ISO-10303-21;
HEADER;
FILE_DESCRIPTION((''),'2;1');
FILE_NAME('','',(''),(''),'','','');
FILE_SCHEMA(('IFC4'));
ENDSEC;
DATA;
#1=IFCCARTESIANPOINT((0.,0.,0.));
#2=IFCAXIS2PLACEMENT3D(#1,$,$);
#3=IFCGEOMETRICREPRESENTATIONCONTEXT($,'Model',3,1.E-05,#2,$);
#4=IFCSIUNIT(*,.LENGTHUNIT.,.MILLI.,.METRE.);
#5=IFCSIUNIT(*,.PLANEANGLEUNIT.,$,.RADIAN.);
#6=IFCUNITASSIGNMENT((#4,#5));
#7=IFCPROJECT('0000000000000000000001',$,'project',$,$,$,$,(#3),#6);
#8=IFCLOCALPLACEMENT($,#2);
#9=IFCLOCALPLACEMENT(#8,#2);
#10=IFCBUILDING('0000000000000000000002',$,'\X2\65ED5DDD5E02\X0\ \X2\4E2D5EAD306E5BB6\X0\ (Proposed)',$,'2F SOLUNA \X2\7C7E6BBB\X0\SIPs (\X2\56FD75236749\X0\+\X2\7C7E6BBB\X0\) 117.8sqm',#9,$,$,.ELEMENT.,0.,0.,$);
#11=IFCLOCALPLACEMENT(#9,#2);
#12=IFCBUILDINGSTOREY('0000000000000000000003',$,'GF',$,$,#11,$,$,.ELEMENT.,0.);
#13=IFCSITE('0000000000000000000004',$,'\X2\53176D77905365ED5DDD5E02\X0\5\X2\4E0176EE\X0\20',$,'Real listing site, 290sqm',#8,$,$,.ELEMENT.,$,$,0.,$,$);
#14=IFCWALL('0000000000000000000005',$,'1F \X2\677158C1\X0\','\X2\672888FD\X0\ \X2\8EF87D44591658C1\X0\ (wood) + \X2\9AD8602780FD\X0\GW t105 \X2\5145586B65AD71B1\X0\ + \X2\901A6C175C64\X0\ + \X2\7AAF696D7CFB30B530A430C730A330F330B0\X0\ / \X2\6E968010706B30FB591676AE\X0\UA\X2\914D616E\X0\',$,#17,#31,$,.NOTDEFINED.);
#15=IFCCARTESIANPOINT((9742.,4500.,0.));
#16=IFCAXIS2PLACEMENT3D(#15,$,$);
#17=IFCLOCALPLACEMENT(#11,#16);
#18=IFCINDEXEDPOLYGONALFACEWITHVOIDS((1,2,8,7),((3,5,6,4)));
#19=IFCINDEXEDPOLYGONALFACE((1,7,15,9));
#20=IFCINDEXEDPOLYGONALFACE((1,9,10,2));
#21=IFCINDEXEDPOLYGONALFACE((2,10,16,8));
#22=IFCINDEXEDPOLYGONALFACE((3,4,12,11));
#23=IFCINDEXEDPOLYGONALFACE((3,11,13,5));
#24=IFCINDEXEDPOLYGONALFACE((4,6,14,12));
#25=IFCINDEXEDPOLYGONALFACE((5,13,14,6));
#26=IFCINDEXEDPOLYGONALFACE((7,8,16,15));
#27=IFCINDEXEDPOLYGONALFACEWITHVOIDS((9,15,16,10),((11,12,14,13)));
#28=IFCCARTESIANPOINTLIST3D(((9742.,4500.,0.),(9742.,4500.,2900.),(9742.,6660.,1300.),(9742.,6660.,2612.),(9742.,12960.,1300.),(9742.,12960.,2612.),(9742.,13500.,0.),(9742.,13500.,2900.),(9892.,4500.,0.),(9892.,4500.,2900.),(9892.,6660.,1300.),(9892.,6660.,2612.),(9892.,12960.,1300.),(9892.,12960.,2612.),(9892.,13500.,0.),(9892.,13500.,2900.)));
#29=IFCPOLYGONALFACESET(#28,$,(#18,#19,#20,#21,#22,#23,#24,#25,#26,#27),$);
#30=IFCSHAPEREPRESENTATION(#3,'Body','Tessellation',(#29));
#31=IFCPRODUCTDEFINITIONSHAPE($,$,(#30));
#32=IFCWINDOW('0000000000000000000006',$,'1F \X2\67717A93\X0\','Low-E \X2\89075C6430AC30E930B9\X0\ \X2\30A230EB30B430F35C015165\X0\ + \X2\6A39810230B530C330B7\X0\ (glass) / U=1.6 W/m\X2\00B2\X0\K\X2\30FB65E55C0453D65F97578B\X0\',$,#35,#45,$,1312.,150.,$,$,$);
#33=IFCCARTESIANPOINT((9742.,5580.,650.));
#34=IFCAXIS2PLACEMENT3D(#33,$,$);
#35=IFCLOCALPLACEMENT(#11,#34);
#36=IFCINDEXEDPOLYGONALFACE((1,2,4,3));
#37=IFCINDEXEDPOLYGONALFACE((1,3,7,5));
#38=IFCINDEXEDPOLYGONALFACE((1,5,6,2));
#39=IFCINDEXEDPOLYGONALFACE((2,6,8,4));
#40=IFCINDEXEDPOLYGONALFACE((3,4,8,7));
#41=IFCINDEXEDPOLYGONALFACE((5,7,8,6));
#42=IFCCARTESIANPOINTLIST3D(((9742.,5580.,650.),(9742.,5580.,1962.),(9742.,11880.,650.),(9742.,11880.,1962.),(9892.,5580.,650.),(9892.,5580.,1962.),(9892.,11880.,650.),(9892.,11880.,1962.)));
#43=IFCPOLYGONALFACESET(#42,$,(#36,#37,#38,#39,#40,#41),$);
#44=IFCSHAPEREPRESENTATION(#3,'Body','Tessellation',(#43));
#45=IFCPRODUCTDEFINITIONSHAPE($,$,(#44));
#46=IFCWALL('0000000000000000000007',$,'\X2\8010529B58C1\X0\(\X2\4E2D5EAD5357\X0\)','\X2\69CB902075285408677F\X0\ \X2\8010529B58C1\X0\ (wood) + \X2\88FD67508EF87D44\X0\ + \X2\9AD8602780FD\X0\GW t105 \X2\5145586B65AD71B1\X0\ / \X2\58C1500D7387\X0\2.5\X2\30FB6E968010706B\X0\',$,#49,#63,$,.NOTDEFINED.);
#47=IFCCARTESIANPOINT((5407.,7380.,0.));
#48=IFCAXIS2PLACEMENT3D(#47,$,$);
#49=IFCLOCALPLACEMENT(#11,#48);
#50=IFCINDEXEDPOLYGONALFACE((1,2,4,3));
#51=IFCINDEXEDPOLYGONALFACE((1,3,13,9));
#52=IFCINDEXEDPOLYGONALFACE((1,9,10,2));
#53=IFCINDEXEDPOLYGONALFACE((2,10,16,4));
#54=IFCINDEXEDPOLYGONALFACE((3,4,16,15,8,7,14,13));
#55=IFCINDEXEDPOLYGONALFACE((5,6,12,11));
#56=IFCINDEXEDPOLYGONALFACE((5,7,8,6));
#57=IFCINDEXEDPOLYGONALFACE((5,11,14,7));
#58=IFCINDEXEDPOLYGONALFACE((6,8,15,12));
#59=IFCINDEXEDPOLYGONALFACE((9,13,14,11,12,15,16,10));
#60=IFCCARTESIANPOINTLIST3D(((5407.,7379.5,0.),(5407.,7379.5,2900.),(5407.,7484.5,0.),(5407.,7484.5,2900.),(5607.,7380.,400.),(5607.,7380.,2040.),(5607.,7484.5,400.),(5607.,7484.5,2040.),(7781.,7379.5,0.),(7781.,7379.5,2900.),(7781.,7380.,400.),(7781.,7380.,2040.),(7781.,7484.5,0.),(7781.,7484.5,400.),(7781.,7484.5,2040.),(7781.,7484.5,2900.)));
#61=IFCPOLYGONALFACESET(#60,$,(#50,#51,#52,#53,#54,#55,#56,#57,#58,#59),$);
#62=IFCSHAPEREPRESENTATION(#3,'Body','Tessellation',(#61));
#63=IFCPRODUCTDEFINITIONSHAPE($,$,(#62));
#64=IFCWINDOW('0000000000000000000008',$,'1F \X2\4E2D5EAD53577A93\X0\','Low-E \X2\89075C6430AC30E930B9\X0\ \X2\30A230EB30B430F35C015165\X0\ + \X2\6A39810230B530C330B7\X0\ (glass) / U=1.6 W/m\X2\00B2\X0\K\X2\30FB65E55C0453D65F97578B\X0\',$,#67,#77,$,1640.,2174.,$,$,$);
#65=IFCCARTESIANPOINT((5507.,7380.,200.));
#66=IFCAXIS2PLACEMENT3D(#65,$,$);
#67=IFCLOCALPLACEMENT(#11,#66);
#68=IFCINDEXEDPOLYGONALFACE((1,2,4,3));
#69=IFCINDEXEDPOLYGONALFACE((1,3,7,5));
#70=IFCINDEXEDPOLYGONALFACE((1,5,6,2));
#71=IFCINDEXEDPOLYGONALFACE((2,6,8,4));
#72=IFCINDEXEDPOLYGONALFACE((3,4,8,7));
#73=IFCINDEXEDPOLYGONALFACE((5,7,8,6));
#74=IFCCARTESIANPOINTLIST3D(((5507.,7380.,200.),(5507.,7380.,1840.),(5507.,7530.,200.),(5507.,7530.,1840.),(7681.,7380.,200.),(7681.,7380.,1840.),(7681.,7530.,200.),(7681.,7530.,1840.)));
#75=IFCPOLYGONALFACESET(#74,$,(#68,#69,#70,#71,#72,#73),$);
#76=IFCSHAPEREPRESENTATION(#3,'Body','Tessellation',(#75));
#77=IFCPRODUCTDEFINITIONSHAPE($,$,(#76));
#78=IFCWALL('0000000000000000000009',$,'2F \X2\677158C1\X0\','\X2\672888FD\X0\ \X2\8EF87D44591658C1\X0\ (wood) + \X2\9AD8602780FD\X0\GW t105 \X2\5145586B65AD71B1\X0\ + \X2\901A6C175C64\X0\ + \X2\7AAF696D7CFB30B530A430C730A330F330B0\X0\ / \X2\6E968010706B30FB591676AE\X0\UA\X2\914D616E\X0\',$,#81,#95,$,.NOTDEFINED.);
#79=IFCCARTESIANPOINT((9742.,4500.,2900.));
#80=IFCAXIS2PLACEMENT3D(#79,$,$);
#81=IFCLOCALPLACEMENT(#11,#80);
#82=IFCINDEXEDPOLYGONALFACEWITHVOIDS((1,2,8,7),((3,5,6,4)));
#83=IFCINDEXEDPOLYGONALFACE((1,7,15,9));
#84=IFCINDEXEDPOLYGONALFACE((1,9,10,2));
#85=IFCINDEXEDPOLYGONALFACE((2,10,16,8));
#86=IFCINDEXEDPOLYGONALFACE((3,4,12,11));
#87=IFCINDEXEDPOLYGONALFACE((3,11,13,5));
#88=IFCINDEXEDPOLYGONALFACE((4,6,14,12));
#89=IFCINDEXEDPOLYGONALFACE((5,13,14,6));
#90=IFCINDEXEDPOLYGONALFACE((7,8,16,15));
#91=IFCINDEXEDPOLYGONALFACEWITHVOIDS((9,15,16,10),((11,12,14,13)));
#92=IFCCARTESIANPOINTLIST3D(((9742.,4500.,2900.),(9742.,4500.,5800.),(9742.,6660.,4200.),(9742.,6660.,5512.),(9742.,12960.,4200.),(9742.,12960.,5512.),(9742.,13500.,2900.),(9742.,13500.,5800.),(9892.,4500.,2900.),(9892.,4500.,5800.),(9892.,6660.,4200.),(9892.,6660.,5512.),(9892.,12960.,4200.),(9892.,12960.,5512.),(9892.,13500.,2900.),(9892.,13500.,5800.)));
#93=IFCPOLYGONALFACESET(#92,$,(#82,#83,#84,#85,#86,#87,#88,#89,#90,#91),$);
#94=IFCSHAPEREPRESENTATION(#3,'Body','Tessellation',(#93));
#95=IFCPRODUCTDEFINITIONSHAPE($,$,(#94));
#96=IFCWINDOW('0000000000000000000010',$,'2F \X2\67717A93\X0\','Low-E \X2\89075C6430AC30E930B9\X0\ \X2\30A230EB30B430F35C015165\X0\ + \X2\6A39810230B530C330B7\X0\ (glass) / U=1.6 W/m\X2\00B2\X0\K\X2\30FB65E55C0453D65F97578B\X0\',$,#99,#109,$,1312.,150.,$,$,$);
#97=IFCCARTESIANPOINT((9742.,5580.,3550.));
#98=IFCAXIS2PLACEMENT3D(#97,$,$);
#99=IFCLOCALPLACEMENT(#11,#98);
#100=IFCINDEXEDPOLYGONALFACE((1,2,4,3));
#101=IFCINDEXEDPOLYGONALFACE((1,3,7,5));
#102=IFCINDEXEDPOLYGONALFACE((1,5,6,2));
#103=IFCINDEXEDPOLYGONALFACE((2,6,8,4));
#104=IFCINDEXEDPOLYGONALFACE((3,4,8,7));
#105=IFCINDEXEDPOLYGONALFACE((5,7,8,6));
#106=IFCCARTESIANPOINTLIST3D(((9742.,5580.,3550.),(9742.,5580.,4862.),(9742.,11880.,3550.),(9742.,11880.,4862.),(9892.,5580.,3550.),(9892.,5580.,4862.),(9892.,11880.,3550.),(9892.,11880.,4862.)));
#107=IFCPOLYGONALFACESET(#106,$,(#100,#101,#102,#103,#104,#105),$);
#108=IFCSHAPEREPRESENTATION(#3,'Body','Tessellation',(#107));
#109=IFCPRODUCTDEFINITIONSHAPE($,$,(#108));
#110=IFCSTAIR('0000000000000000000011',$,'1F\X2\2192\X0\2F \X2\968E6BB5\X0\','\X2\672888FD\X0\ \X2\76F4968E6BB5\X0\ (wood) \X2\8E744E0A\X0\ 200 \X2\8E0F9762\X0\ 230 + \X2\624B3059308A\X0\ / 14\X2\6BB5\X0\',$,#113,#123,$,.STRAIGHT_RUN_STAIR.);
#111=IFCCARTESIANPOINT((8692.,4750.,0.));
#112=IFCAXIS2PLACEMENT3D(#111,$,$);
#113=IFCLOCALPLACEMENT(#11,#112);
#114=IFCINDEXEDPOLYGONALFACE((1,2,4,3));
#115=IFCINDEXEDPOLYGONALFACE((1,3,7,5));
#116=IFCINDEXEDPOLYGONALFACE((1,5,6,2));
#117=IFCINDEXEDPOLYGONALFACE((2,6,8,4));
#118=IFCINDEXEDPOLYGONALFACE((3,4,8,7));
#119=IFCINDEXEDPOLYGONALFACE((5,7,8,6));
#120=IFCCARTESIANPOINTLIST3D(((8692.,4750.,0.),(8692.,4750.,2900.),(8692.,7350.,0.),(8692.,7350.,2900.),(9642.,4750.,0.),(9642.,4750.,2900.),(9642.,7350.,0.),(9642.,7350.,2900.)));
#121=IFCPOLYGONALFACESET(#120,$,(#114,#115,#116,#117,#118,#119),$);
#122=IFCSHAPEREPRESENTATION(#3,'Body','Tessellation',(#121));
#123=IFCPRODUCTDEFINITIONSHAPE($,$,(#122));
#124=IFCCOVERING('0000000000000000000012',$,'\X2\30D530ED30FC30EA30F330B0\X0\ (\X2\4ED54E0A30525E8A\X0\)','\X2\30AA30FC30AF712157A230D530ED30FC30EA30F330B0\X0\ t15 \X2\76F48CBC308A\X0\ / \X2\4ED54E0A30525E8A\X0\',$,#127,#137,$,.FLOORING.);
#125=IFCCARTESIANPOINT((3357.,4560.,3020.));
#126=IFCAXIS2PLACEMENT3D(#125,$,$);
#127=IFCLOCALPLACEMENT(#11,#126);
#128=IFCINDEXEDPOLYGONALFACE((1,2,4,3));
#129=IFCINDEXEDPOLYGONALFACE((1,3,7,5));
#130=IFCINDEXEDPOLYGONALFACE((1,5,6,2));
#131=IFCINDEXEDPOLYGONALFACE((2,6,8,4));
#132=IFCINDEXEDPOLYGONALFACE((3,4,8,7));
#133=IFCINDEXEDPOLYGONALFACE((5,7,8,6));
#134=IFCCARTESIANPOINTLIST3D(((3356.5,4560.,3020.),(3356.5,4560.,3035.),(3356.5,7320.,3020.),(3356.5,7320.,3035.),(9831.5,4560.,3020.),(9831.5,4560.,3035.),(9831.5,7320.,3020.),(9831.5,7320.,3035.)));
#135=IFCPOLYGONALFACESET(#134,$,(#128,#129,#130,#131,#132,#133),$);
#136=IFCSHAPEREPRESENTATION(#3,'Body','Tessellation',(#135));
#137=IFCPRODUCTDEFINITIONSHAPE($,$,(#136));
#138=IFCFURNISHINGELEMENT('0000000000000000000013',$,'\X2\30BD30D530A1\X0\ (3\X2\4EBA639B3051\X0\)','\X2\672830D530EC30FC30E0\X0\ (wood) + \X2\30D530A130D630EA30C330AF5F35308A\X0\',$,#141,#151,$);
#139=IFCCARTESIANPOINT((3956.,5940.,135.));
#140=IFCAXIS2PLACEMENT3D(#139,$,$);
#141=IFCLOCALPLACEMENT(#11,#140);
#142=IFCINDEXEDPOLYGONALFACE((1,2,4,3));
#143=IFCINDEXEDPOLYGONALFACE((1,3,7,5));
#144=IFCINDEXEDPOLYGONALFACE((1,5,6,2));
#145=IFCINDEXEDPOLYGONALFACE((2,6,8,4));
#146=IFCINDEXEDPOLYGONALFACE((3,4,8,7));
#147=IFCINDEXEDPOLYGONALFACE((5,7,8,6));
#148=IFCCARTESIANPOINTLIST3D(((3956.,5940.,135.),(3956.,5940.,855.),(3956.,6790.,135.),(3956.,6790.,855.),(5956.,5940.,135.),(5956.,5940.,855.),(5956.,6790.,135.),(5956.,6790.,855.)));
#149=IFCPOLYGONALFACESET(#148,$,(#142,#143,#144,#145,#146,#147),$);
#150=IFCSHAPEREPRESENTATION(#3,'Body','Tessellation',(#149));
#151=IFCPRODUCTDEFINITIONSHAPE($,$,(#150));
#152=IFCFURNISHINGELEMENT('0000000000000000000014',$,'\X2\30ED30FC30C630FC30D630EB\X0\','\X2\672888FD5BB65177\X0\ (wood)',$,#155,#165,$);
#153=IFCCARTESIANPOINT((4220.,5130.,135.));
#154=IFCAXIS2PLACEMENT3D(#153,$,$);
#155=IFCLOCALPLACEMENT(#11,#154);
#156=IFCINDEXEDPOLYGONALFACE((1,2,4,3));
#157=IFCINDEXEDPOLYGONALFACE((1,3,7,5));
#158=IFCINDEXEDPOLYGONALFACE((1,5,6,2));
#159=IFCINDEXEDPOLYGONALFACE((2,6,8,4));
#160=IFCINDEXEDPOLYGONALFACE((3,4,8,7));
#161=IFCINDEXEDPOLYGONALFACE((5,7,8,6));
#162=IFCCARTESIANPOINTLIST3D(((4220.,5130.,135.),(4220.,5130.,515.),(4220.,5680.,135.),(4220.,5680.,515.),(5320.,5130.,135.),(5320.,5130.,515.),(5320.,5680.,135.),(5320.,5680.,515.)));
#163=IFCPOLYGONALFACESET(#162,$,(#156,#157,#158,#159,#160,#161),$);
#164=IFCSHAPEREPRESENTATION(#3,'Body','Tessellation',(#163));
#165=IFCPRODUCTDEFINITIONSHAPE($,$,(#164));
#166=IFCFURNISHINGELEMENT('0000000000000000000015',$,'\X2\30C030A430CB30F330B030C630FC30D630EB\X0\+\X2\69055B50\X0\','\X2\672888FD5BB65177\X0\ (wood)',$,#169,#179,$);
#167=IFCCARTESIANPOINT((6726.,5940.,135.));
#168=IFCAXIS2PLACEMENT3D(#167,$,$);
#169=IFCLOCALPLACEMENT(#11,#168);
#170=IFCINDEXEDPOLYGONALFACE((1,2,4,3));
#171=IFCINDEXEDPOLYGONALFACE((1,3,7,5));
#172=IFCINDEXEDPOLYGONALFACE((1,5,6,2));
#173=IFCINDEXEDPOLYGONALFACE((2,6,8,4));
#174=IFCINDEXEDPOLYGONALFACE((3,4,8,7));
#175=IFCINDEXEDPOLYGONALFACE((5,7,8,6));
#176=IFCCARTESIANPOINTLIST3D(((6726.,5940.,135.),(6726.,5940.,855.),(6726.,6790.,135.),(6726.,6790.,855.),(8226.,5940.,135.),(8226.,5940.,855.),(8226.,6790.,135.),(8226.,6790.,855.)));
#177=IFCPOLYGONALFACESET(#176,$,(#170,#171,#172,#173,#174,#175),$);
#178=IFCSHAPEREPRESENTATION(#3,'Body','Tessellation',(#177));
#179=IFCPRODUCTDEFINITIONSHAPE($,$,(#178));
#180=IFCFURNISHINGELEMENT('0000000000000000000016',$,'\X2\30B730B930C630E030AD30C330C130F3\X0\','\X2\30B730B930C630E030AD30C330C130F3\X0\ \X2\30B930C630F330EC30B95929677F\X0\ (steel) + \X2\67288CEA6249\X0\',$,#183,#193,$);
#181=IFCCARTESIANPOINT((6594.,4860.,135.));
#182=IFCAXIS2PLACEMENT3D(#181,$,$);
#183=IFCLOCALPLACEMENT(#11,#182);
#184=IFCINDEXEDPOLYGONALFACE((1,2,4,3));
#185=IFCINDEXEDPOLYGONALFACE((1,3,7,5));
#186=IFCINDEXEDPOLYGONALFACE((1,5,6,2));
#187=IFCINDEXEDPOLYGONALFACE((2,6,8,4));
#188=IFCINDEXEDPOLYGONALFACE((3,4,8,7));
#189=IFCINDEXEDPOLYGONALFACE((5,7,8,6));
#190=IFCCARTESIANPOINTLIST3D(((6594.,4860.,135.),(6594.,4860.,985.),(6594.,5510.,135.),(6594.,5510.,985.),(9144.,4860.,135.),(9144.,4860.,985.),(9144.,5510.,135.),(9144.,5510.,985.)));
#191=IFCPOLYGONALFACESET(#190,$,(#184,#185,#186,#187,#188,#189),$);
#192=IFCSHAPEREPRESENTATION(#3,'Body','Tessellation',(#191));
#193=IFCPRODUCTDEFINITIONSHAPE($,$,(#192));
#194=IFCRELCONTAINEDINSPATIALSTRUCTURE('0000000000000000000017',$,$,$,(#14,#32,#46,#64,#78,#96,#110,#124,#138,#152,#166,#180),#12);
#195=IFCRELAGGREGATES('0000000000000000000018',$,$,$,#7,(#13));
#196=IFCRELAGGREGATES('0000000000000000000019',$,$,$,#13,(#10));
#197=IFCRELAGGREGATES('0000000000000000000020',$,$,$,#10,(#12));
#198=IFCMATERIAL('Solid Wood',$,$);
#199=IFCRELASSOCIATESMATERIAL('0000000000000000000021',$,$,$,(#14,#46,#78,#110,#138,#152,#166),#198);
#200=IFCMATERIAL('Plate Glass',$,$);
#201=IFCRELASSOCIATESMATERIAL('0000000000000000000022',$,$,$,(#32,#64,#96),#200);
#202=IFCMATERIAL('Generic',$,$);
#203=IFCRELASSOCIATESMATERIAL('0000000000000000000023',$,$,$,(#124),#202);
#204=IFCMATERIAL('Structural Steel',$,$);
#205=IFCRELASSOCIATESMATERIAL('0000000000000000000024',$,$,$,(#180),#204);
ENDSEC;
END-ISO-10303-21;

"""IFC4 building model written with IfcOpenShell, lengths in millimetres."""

from ifc_helpers import new_model, si_unit, frame, frame_2d, origin, place, context, project, spatial, rectangle, extrude, material, element, fill, save


model = new_model("IFC4")

# Units and contexts
model_context = context("Model", 3, precision=1e-05, world=origin())
ifc_project = project(units=[si_unit("LENGTHUNIT", "METRE", prefix="MILLI"), si_unit("PLANEANGLEUNIT", "RADIAN")], contexts=[model_context])

# Site, building, storey
site_placement = place(None, origin())
site = spatial("IfcSite", under=ifc_project, at=site_placement, Name="北海道旭川市5丁目20", ObjectType="Real listing site, 290sqm", CompositionType="ELEMENT", RefElevation=0.0)
building_placement = place(site_placement, origin())
building = spatial("IfcBuilding", under=site, at=building_placement, Name="旭川市 中庭の家 (Proposed)", ObjectType="2F SOLUNA 籾殻SIPs (国産杉+籾殻) 117.8sqm", CompositionType="ELEMENT", ElevationOfRefHeight=0.0, ElevationOfTerrain=0.0)
storey_placement = place(building_placement, origin())
storey = spatial("IfcBuildingStorey", under=building, at=storey_placement, Name="GF", CompositionType="ELEMENT", Elevation=0.0)

# Shared definitions
ifc_material_1 = material(Name="Solid Wood")

# Walls, openings, windows
wall_1_placement = place(storey_placement, frame((9742.0, 4500.0, 0.0)))
wall_1 = element("IfcWall", 1, at=wall_1_placement, inside=storey, material=ifc_material_1, Name="1F 東壁", Description="木製 軸組外壁 (wood) + 高性能GW t105 充填断熱 + 通気層 + 窯業系サイディング / 準耐火・外皮UA配慮", PredefinedType="NOTDEFINED", context=model_context, shape_type="SweptSolid", body=[
    extrude(rectangle(XDim=150.0, YDim=9000.0, at=frame_2d((75.0, 4500.0))), frame((9742.0, 4500.0, 0.0)), (0.0, 0.0, 1.0), 2900.0),
])
opening_1_placement = place(storey_placement, frame((9742.0, 5580.0, 650.0)))
opening_1 = element("IfcOpeningElement", 2, at=opening_1_placement, cuts=wall_1, PredefinedType="NOTDEFINED", context=model_context, shape_type="SweptSolid", body=[
    extrude(rectangle(XDim=150.0, YDim=6300.0, at=frame_2d((75.0, 3150.0))), frame((9742.0, 5580.0, 650.0)), (0.0, 0.0, 1.0), 1312.0),
])
ifc_material_2 = material(Name="Plate Glass")
window_1_placement = place(storey_placement, frame((9742.0, 5580.0, 650.0)))
window_1 = element("IfcWindow", 3, at=window_1_placement, inside=storey, material=ifc_material_2, Name="1F 東窓", Description="Low-E 複層ガラス アルゴン封入 + 樹脂サッシ (glass) / U=1.6 W/m²K・日射取得型", OverallHeight=1312.0, OverallWidth=150.0, context=model_context, shape_type="SweptSolid", body=[
    extrude(rectangle(XDim=150.0, YDim=6300.0, at=frame_2d((75.0, 3150.0))), frame((9742.0, 5580.0, 650.0)), (0.0, 0.0, 1.0), 1312.0),
])
fill(opening_1, window_1)
wall_2_placement = place(storey_placement, frame((5407.0, 7380.0, 0.0)))
wall_2 = element("IfcWall", 4, at=wall_2_placement, inside=storey, material=ifc_material_1, Name="耐力壁(中庭南)", Description="構造用合板 耐力壁 (wood) + 製材軸組 + 高性能GW t105 充填断熱 / 壁倍率2.5・準耐火", PredefinedType="NOTDEFINED", context=model_context, shape_type="SweptSolid", body=[
    extrude(rectangle(XDim=2374.0, YDim=105.0, at=frame_2d((1187.0, 52.0))), frame((5407.0, 7380.0, 0.0)), (0.0, 0.0, 1.0), 2900.0),
])
opening_2_placement = place(storey_placement, frame((5507.0, 7380.0, 200.0)))
opening_2 = element("IfcOpeningElement", 5, at=opening_2_placement, cuts=wall_2, PredefinedType="NOTDEFINED", context=model_context, shape_type="SweptSolid", body=[
    extrude(rectangle(XDim=2174.0, YDim=150.0, at=frame_2d((1087.0, 75.0))), frame((5507.0, 7380.0, 200.0)), (0.0, 0.0, 1.0), 1640.0),
])
window_2_placement = place(storey_placement, frame((5507.0, 7380.0, 200.0)))
window_2 = element("IfcWindow", 6, at=window_2_placement, inside=storey, material=ifc_material_2, Name="1F 中庭南窓", Description="Low-E 複層ガラス アルゴン封入 + 樹脂サッシ (glass) / U=1.6 W/m²K・日射取得型", OverallHeight=1640.0, OverallWidth=2174.0, context=model_context, shape_type="SweptSolid", body=[
    extrude(rectangle(XDim=2174.0, YDim=150.0, at=frame_2d((1087.0, 75.0))), frame((5507.0, 7380.0, 200.0)), (0.0, 0.0, 1.0), 1640.0),
])
fill(opening_2, window_2)

# Wall, opening, window
wall_3_placement = place(storey_placement, frame((9742.0, 4500.0, 2900.0)))
wall_3 = element("IfcWall", 7, at=wall_3_placement, inside=storey, material=ifc_material_1, Name="2F 東壁", Description="木製 軸組外壁 (wood) + 高性能GW t105 充填断熱 + 通気層 + 窯業系サイディング / 準耐火・外皮UA配慮", PredefinedType="NOTDEFINED", context=model_context, shape_type="SweptSolid", body=[
    extrude(rectangle(XDim=150.0, YDim=9000.0, at=frame_2d((75.0, 4500.0))), frame((9742.0, 4500.0, 2900.0)), (0.0, 0.0, 1.0), 2900.0),
])
opening_3_placement = place(storey_placement, frame((9742.0, 5580.0, 3550.0)))
opening_3 = element("IfcOpeningElement", 8, at=opening_3_placement, cuts=wall_3, PredefinedType="NOTDEFINED", context=model_context, shape_type="SweptSolid", body=[
    extrude(rectangle(XDim=150.0, YDim=6300.0, at=frame_2d((75.0, 3150.0))), frame((9742.0, 5580.0, 3550.0)), (0.0, 0.0, 1.0), 1312.0),
])
window_3_placement = place(storey_placement, frame((9742.0, 5580.0, 3550.0)))
window_3 = element("IfcWindow", 9, at=window_3_placement, inside=storey, material=ifc_material_2, Name="2F 東窓", Description="Low-E 複層ガラス アルゴン封入 + 樹脂サッシ (glass) / U=1.6 W/m²K・日射取得型", OverallHeight=1312.0, OverallWidth=150.0, context=model_context, shape_type="SweptSolid", body=[
    extrude(rectangle(XDim=150.0, YDim=6300.0, at=frame_2d((75.0, 3150.0))), frame((9742.0, 5580.0, 3550.0)), (0.0, 0.0, 1.0), 1312.0),
])
fill(opening_3, window_3)

# Stair
stair_placement = place(storey_placement, frame((8692.0, 4750.0, 0.0)))
element("IfcStair", 10, at=stair_placement, inside=storey, material=ifc_material_1, Name="1F→2F 階段", Description="木製 直階段 (wood) 蹴上 200 踏面 230 + 手すり / 14段", PredefinedType="STRAIGHT_RUN_STAIR", context=model_context, shape_type="SweptSolid", body=[
    extrude(rectangle(XDim=950.0, YDim=2600.0, at=frame_2d((475.0, 1300.0))), frame((8692.0, 4750.0, 0.0)), (0.0, 0.0, 1.0), 2900.0),
])

# Covering
ifc_material_3 = material(Name="Generic")
covering_placement = place(storey_placement, frame((3357.0, 4560.0, 3020.0)))
element("IfcCovering", 11, at=covering_placement, inside=storey, material=ifc_material_3, Name="フローリング (仕上げ床)", Description="オーク無垢フローリング t15 直貼り / 仕上げ床", PredefinedType="FLOORING", context=model_context, shape_type="SweptSolid", body=[
    extrude(rectangle(XDim=6475.0, YDim=2760.0, at=frame_2d((3237.0, 1380.0))), frame((3357.0, 4560.0, 3020.0)), (0.0, 0.0, 1.0), 15.0),
])

# Furnishing elements
furnishing_1_placement = place(storey_placement, frame((3956.0, 5940.0, 135.0)))
element("IfcFurnishingElement", 12, at=furnishing_1_placement, inside=storey, material=ifc_material_1, Name="ソファ (3人掛け)", Description="木フレーム (wood) + ファブリック張り", context=model_context, shape_type="SweptSolid", body=[
    extrude(rectangle(XDim=2000.0, YDim=850.0, at=frame_2d((1000.0, 425.0))), frame((3956.0, 5940.0, 135.0)), (0.0, 0.0, 1.0), 720.0),
])
furnishing_2_placement = place(storey_placement, frame((4220.0, 5130.0, 135.0)))
element("IfcFurnishingElement", 13, at=furnishing_2_placement, inside=storey, material=ifc_material_1, Name="ローテーブル", Description="木製家具 (wood)", context=model_context, shape_type="SweptSolid", body=[
    extrude(rectangle(XDim=1100.0, YDim=550.0, at=frame_2d((550.0, 275.0))), frame((4220.0, 5130.0, 135.0)), (0.0, 0.0, 1.0), 380.0),
])
furnishing_3_placement = place(storey_placement, frame((6726.0, 5940.0, 135.0)))
element("IfcFurnishingElement", 14, at=furnishing_3_placement, inside=storey, material=ifc_material_1, Name="ダイニングテーブル+椅子", Description="木製家具 (wood)", context=model_context, shape_type="SweptSolid", body=[
    extrude(rectangle(XDim=1500.0, YDim=850.0, at=frame_2d((750.0, 425.0))), frame((6726.0, 5940.0, 135.0)), (0.0, 0.0, 1.0), 720.0),
])
ifc_material_4 = material(Name="Structural Steel")
furnishing_4_placement = place(storey_placement, frame((6594.0, 4860.0, 135.0)))
element("IfcFurnishingElement", 15, at=furnishing_4_placement, inside=storey, material=ifc_material_4, Name="システムキッチン", Description="システムキッチン ステンレス天板 (steel) + 木質扉", context=model_context, shape_type="SweptSolid", body=[
    extrude(rectangle(XDim=2550.0, YDim=650.0, at=frame_2d((1275.0, 325.0))), frame((6594.0, 4860.0, 135.0)), (0.0, 0.0, 1.0), 850.0),
])

save(model, "model.ifc")
